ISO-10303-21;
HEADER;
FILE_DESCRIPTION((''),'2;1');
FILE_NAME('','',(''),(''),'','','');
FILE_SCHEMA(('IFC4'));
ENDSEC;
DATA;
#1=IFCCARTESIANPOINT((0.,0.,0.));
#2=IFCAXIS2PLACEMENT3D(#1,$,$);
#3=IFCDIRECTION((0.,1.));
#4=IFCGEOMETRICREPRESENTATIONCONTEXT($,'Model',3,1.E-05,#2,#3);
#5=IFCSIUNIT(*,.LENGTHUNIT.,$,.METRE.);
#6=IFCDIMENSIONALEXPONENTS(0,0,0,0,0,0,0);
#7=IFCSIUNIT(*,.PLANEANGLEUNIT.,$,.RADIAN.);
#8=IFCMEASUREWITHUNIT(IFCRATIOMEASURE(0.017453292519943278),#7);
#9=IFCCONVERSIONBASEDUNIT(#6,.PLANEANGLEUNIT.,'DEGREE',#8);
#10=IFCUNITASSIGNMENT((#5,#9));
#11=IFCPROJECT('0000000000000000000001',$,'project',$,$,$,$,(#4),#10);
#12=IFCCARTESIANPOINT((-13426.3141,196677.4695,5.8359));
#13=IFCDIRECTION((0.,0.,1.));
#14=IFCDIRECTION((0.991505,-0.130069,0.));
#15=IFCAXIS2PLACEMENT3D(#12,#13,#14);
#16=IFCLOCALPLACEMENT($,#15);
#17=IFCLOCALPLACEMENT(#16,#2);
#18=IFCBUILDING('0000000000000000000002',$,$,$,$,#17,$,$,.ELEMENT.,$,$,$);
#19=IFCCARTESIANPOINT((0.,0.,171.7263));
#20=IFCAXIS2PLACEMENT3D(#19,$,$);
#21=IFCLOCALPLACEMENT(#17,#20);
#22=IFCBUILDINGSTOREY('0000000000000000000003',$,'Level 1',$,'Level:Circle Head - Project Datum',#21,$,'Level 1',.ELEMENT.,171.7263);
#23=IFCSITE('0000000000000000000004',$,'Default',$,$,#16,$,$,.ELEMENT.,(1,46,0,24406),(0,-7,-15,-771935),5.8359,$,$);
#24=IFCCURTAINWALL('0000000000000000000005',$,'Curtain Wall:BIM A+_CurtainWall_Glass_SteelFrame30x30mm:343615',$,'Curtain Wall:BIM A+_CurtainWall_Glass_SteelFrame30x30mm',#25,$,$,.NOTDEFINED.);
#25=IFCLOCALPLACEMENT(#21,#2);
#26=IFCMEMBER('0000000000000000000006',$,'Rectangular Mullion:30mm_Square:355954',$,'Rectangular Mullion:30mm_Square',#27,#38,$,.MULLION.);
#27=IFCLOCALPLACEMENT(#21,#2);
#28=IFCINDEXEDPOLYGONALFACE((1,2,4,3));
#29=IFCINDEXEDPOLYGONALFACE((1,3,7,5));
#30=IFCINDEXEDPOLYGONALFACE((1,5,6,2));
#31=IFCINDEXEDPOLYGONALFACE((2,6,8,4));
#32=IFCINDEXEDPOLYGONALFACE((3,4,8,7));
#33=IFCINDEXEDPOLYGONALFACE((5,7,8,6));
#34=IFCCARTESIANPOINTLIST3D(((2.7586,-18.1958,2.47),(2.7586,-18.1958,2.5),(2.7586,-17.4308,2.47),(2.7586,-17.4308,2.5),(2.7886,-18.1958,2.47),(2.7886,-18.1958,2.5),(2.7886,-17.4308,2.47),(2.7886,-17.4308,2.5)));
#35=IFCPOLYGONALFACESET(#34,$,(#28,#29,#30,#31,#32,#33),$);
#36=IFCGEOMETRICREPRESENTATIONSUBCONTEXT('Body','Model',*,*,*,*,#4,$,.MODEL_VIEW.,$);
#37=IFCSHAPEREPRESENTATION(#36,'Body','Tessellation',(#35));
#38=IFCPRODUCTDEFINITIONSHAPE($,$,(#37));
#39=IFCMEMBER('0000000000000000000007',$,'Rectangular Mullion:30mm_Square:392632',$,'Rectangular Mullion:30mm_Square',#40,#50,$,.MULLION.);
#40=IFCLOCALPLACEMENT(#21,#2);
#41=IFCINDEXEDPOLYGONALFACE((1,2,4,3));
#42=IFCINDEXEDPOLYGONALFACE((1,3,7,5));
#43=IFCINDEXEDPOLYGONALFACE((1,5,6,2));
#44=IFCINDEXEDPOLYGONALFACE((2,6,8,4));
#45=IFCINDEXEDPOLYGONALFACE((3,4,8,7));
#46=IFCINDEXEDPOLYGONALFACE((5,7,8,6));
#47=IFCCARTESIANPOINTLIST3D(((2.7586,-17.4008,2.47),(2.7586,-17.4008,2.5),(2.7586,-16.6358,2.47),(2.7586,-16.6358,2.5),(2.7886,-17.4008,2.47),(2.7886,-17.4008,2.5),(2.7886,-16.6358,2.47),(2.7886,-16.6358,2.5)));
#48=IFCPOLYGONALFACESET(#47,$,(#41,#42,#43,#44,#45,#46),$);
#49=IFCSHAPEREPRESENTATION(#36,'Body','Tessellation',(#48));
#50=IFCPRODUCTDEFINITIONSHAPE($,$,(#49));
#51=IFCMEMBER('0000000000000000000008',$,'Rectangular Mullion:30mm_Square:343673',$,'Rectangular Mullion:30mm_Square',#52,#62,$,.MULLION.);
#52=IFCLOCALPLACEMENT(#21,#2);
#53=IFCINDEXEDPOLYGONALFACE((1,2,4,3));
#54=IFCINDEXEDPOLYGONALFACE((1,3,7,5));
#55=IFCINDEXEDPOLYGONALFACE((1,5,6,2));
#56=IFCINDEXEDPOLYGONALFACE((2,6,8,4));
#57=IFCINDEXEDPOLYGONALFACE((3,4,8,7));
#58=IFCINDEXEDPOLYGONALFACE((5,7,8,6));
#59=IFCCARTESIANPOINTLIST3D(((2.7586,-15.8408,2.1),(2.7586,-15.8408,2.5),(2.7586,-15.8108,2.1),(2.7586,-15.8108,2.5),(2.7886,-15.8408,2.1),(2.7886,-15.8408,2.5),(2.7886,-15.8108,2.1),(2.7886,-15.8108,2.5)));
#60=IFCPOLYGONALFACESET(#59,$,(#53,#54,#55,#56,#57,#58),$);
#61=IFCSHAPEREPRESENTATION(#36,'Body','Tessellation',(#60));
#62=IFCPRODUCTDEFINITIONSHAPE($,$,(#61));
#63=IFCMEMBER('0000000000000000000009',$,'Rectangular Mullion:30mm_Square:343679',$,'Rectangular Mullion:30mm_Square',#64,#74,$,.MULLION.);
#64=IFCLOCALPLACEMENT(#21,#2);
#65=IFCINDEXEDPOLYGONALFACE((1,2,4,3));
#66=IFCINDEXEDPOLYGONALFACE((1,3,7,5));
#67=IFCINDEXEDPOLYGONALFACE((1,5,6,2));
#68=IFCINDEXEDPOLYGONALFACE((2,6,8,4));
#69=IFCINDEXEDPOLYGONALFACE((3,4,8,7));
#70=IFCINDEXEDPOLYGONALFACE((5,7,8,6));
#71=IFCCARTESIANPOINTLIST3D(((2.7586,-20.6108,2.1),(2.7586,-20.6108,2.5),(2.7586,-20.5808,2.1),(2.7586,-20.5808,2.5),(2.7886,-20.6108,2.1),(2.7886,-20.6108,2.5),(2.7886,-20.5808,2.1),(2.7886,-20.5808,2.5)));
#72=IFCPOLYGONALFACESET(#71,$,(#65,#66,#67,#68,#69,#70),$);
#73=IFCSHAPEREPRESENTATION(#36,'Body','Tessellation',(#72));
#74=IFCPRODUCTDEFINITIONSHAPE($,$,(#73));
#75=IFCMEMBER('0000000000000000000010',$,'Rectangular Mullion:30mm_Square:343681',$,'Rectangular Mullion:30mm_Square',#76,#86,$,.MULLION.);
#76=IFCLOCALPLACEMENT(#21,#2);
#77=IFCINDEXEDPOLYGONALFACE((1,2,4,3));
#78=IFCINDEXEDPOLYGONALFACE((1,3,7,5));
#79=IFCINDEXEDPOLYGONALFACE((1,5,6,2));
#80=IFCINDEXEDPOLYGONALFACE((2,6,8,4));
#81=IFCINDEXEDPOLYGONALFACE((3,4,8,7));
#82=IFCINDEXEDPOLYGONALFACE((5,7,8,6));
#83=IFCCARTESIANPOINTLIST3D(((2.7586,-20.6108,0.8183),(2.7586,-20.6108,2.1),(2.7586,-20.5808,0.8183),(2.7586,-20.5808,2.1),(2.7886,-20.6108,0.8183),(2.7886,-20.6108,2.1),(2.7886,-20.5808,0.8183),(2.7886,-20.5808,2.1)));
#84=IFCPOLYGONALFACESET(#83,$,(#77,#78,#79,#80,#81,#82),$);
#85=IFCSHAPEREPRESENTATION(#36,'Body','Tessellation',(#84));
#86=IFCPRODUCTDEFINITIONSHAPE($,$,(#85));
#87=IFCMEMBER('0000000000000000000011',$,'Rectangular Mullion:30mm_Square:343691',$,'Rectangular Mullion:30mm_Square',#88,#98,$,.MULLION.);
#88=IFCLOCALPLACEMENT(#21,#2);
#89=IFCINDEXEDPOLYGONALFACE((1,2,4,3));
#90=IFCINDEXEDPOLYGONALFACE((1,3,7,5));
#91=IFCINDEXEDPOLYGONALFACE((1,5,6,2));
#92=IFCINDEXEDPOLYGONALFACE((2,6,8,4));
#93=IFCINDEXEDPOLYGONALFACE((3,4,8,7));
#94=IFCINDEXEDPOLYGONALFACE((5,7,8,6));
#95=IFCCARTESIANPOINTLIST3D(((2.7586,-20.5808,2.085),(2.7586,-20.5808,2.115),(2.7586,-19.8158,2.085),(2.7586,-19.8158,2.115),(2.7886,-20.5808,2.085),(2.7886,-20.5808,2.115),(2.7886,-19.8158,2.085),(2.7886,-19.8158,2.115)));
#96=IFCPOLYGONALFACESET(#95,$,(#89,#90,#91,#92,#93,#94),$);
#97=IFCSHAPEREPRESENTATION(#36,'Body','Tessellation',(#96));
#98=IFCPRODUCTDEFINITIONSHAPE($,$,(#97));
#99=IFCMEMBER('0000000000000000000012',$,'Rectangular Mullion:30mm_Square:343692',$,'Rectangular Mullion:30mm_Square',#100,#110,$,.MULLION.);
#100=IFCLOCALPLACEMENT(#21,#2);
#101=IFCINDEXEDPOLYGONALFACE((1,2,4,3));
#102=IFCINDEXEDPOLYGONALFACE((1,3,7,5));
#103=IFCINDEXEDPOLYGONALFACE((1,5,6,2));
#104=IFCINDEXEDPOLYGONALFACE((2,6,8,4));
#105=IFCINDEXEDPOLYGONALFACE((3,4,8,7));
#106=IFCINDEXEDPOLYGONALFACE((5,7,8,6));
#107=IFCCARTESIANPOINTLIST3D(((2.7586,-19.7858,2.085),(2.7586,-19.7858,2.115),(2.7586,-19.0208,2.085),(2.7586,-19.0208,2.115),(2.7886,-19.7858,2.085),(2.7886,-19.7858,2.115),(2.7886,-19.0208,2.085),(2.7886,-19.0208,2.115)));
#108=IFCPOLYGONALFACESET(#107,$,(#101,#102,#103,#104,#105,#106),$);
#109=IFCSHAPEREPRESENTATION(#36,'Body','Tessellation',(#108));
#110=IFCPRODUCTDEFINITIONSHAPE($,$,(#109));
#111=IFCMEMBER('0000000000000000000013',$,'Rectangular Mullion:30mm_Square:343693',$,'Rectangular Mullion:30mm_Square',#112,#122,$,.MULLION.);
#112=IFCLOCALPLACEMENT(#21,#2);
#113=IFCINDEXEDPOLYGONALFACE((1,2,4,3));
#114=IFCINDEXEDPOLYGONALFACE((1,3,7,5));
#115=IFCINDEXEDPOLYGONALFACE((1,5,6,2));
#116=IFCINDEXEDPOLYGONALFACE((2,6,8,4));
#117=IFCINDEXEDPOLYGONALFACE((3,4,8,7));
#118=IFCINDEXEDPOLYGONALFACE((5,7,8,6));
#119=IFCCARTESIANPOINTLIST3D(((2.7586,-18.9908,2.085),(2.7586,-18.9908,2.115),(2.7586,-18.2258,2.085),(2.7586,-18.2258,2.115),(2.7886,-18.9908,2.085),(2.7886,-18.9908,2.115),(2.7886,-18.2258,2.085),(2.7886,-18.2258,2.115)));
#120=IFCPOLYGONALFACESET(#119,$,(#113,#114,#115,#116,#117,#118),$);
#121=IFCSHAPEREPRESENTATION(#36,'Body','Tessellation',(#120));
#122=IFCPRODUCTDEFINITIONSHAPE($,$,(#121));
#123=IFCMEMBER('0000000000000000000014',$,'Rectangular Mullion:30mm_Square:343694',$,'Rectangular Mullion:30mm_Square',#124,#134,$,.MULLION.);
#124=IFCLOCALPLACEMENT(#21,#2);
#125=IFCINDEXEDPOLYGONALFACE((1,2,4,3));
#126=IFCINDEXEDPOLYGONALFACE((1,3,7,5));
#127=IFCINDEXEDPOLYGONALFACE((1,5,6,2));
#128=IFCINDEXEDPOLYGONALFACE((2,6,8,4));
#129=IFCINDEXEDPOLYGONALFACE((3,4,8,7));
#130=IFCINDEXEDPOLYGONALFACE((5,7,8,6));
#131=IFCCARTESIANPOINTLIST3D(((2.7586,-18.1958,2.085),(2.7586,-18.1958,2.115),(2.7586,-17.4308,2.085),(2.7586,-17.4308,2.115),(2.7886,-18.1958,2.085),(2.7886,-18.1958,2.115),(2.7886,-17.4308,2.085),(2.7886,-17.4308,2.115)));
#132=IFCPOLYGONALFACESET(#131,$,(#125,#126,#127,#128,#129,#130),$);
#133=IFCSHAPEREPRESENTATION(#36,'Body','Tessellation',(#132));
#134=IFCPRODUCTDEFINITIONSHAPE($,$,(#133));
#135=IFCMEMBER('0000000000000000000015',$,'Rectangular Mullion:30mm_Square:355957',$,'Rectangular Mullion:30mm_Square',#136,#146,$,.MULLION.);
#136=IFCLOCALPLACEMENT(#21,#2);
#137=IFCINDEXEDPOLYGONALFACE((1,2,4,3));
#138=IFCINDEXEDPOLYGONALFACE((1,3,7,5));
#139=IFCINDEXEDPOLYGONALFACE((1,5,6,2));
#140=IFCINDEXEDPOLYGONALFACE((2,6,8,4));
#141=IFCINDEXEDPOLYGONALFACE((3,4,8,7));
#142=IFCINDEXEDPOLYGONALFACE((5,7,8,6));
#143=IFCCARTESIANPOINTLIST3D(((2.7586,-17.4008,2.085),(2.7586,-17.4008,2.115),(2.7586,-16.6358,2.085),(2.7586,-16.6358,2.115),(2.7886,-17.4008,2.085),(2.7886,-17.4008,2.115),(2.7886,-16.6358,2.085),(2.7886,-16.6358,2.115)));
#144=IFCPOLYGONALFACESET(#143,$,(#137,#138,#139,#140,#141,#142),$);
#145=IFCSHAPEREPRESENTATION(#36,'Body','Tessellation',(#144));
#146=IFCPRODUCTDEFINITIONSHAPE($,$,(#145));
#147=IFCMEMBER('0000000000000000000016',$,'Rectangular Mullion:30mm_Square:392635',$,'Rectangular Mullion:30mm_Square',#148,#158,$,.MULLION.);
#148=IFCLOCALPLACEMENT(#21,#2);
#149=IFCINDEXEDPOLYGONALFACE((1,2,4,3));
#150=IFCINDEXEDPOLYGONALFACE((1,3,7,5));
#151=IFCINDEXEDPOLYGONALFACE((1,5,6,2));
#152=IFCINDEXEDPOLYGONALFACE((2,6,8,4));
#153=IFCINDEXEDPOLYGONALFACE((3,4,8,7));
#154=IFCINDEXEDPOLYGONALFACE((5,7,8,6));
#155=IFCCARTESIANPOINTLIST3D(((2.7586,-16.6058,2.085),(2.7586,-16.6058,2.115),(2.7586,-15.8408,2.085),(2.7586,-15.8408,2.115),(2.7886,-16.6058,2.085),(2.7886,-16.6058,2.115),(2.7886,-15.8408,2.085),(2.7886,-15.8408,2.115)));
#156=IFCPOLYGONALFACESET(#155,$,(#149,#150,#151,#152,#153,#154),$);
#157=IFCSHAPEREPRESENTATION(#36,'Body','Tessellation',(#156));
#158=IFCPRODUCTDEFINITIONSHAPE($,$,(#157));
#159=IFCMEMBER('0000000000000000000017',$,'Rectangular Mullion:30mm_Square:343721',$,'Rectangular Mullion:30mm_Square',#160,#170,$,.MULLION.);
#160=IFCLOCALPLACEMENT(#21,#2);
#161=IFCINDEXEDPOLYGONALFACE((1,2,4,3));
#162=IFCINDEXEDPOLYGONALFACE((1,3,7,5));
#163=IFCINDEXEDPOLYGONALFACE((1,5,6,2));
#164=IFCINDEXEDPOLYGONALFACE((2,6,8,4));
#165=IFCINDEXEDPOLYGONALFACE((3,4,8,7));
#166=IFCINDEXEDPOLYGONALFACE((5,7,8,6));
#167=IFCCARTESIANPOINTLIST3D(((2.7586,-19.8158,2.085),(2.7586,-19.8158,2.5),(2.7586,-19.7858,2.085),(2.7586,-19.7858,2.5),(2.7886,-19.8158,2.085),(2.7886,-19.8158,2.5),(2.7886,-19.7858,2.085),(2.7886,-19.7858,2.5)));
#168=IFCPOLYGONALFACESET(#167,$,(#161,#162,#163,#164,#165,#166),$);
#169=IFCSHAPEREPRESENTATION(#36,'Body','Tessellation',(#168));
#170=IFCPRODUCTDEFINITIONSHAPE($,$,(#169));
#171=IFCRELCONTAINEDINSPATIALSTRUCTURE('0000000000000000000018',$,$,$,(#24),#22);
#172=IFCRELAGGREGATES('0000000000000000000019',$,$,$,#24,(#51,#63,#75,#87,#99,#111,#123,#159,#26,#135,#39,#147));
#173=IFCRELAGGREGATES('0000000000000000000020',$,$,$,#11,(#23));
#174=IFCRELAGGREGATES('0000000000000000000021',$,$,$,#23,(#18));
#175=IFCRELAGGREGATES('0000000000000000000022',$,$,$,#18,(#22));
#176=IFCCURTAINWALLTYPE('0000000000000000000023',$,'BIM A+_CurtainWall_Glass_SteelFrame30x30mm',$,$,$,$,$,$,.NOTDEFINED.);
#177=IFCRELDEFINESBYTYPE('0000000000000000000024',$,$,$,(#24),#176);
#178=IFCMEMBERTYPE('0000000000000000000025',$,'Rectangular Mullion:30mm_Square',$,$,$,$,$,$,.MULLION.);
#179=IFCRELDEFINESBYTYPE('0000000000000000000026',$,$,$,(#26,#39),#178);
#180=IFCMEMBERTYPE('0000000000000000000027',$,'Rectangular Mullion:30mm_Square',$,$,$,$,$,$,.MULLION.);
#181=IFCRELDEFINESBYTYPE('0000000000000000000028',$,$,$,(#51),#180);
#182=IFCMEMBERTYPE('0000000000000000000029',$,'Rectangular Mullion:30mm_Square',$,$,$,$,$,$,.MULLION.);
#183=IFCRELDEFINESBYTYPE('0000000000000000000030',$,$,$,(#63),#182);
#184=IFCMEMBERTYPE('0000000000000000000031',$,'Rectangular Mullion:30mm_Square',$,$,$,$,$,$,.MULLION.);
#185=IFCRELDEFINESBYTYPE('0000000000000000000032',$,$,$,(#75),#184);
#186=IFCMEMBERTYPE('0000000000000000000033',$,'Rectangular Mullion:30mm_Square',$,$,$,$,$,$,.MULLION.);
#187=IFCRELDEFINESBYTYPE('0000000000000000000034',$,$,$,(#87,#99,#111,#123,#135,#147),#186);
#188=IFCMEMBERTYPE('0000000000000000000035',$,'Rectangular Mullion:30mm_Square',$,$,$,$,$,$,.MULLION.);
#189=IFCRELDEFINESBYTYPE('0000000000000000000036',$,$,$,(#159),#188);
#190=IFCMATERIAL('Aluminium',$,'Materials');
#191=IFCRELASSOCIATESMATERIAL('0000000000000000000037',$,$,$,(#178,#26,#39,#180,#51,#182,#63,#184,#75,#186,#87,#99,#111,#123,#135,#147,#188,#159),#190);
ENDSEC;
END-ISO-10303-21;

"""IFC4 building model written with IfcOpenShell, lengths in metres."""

from ifc_helpers import new_model, entity, si_unit, converted_unit, direction, frame, origin, place, context, subcontext, project, spatial, indexed_curve, outline, extrude, source, transform, mapped, material, type_object, type_shapes, element, aggregate, save


model = new_model("IFC4")

# Units and contexts
model_context = context("Model", 3, precision=1e-05, world=origin(), true_north=direction((0.0, 1.0)))
body_context = subcontext(model_context, "Body", "Model", "MODEL_VIEW")
ifc_project = project(units=[si_unit("LENGTHUNIT", "METRE"), converted_unit("PLANEANGLEUNIT", "DEGREE", entity("IfcRatioMeasure", 0.017453292519943278), si_unit("PLANEANGLEUNIT", "RADIAN"), dimensions=[0, 0, 0, 0, 0, 0, 0])], contexts=[model_context])

# Site, building, storey
site_placement = place(None, frame((-13426.3141, 196677.4695, 5.8359), z_axis=(0.0, 0.0, 1.0), x_axis=(0.991505, -0.130069, 0.0)))
site = spatial("IfcSite", under=ifc_project, at=site_placement, Name="Default", CompositionType="ELEMENT", RefLatitude=(1, 46, 0, 24406), RefLongitude=(0, -7, -15, -771935), RefElevation=5.8359)
building_placement = place(site_placement, origin())
building = spatial("IfcBuilding", under=site, at=building_placement, CompositionType="ELEMENT")
storey_placement = place(building_placement, frame((0.0, 0.0, 171.7263)))
storey = spatial("IfcBuildingStorey", under=building, at=storey_placement, Name="Level 1", ObjectType="Level:Circle Head - Project Datum", LongName="Level 1", CompositionType="ELEMENT", Elevation=171.7263)

# Curtain wall, members
curtain_wall_type_1 = type_object("IfcCurtainWallType", Name="BIM A+_CurtainWall_Glass_SteelFrame30x30mm", PredefinedType="NOTDEFINED")
ifc_material_1 = material(Name="Aluminium", Category="Materials")
curtain_wall_1_placement = place(storey_placement, frame((0.0, 0.0, -171.7263)))
curtain_wall_1 = element("IfcCurtainWall", 1, at=curtain_wall_1_placement, inside=storey, type_object=curtain_wall_type_1, Name="Curtain Wall:BIM A+_CurtainWall_Glass_SteelFrame30x30mm:343615", ObjectType="Curtain Wall:BIM A+_CurtainWall_Glass_SteelFrame30x30mm", PredefinedType="NOTDEFINED")
member_type_1 = type_object("IfcMemberType", Name="Rectangular Mullion:30mm_Square", PredefinedType="MULLION", material=ifc_material_1)
shared_shape_1 = source(origin(), body_context, "Body", "SweptSolid", [
    extrude(outline(indexed_curve([(-0.015, -0.015), (0.015, -0.015), (0.015, 0.015), (-0.015, 0.015), (-0.015, -0.015)], self_intersect=False)), frame((-0.015, 0.0, -0.765), z_axis=(0.0, 0.0, 1.0), x_axis=(0.0, -1.0, 0.0)), (0.0, 0.0, 1.0), 0.765),
])
type_shapes(member_type_1, [shared_shape_1])
member_1_placement = place(curtain_wall_1_placement, frame((2.7736, -17.4308, 174.2263), z_axis=(0.0, 1.0, 0.0), x_axis=(0.0, 0.0, 1.0)))
member_1 = element("IfcMember", 2, at=member_1_placement, type_object=member_type_1, material=ifc_material_1, Name="Rectangular Mullion:30mm_Square:355954", ObjectType="Rectangular Mullion:30mm_Square", PredefinedType="MULLION", context=body_context, shape_type="MappedRepresentation", body=[
    mapped(shared_shape_1, transform((0.0, 0.0, 0.0), scale=1.0)),
])
member_2_placement = place(curtain_wall_1_placement, frame((2.7736, -16.6358, 174.2263), z_axis=(0.0, 1.0, 0.0), x_axis=(0.0, 0.0, 1.0)))
member_2 = element("IfcMember", 3, at=member_2_placement, type_object=member_type_1, material=ifc_material_1, Name="Rectangular Mullion:30mm_Square:392632", ObjectType="Rectangular Mullion:30mm_Square", PredefinedType="MULLION", context=body_context, shape_type="MappedRepresentation", body=[
    mapped(shared_shape_1, transform((0.0, 0.0, 0.0), scale=1.0)),
])
member_type_2 = type_object("IfcMemberType", Name="Rectangular Mullion:30mm_Square", PredefinedType="MULLION", material=ifc_material_1)
shared_shape_2 = source(origin(), body_context, "Body", "SweptSolid", [
    extrude(outline(indexed_curve([(-0.015, -0.015), (0.015, -0.015), (0.015, 0.015), (-0.015, 0.015), (-0.015, -0.015)], self_intersect=False)), frame((-0.015, 0.0, -0.4), z_axis=(0.0, 0.0, 1.0), x_axis=(0.0, -1.0, 0.0)), (0.0, 0.0, 1.0), 0.4),
])
type_shapes(member_type_2, [shared_shape_2])
member_3_placement = place(curtain_wall_1_placement, frame((2.7736, -15.8108, 173.8263), z_axis=(0.0, 0.0, -1.0), x_axis=(0.0, 1.0, 0.0)))
member_3 = element("IfcMember", 4, at=member_3_placement, type_object=member_type_2, material=ifc_material_1, Name="Rectangular Mullion:30mm_Square:343673", ObjectType="Rectangular Mullion:30mm_Square", PredefinedType="MULLION", context=body_context, shape_type="MappedRepresentation", body=[
    mapped(shared_shape_2, transform((0.0, 0.0, 0.0), scale=1.0)),
])
member_type_3 = type_object("IfcMemberType", Name="Rectangular Mullion:30mm_Square", PredefinedType="MULLION", material=ifc_material_1)
shared_shape_3 = source(origin(), body_context, "Body", "SweptSolid", [
    extrude(outline(indexed_curve([(-0.015, -0.015), (0.015, -0.015), (0.015, 0.015), (-0.015, 0.015), (-0.015, -0.015)], self_intersect=False)), frame((-0.015, 0.0, -0.4), z_axis=(0.0, 0.0, 1.0), x_axis=(0.0, -1.0, 0.0)), (0.0, 0.0, 1.0), 0.4),
])
type_shapes(member_type_3, [shared_shape_3])
member_4_placement = place(curtain_wall_1_placement, frame((2.7736, -20.6108, 174.2263), z_axis=(0.0, 0.0, 1.0), x_axis=(0.0, -1.0, 0.0)))
member_4 = element("IfcMember", 5, at=member_4_placement, type_object=member_type_3, material=ifc_material_1, Name="Rectangular Mullion:30mm_Square:343679", ObjectType="Rectangular Mullion:30mm_Square", PredefinedType="MULLION", context=body_context, shape_type="MappedRepresentation", body=[
    mapped(shared_shape_3, transform((0.0, 0.0, 0.0), scale=1.0)),
])
member_type_4 = type_object("IfcMemberType", Name="Rectangular Mullion:30mm_Square", PredefinedType="MULLION", material=ifc_material_1)
shared_shape_4 = source(origin(), body_context, "Body", "SweptSolid", [
    extrude(outline(indexed_curve([(-0.015, -0.015), (0.015, -0.015), (0.015, 0.015), (-0.015, 0.015), (-0.015, -0.015)], self_intersect=False)), frame((-0.015, 0.0, -1.2817), z_axis=(0.0, 0.0, 1.0), x_axis=(0.0, -1.0, 0.0)), (0.0, 0.0, 1.0), 1.2817),
])
type_shapes(member_type_4, [shared_shape_4])
member_5_placement = place(curtain_wall_1_placement, frame((2.7736, -20.6108, 173.8263), z_axis=(0.0, 0.0, 1.0), x_axis=(0.0, -1.0, 0.0)))
member_5 = element("IfcMember", 6, at=member_5_placement, type_object=member_type_4, material=ifc_material_1, Name="Rectangular Mullion:30mm_Square:343681", ObjectType="Rectangular Mullion:30mm_Square", PredefinedType="MULLION", context=body_context, shape_type="MappedRepresentation", body=[
    mapped(shared_shape_4, transform((0.0, 0.0, 0.0), scale=1.0)),
])
member_type_5 = type_object("IfcMemberType", Name="Rectangular Mullion:30mm_Square", PredefinedType="MULLION", material=ifc_material_1)
shared_shape_5 = source(origin(), body_context, "Body", "SweptSolid", [
    extrude(outline(indexed_curve([(-0.015, -0.015), (0.015, -0.015), (0.015, 0.015), (-0.015, 0.015), (-0.015, -0.015)], self_intersect=False)), frame((0.0, 0.0, -0.765), z_axis=(0.0, 0.0, 1.0), x_axis=(0.0, -1.0, 0.0)), (0.0, 0.0, 1.0), 0.765),
])
type_shapes(member_type_5, [shared_shape_5])
member_6_placement = place(curtain_wall_1_placement, frame((2.7736, -19.8158, 173.8263), z_axis=(0.0, 1.0, 0.0), x_axis=(0.0, 0.0, 1.0)))
member_6 = element("IfcMember", 7, at=member_6_placement, type_object=member_type_5, material=ifc_material_1, Name="Rectangular Mullion:30mm_Square:343691", ObjectType="Rectangular Mullion:30mm_Square", PredefinedType="MULLION", context=body_context, shape_type="MappedRepresentation", body=[
    mapped(shared_shape_5, transform((0.0, 0.0, 0.0), scale=1.0)),
])
member_7_placement = place(curtain_wall_1_placement, frame((2.7736, -19.0208, 173.8263), z_axis=(0.0, 1.0, 0.0), x_axis=(0.0, 0.0, 1.0)))
member_7 = element("IfcMember", 8, at=member_7_placement, type_object=member_type_5, material=ifc_material_1, Name="Rectangular Mullion:30mm_Square:343692", ObjectType="Rectangular Mullion:30mm_Square", PredefinedType="MULLION", context=body_context, shape_type="MappedRepresentation", body=[
    mapped(shared_shape_5, transform((0.0, 0.0, 0.0), scale=1.0)),
])
member_8_placement = place(curtain_wall_1_placement, frame((2.7736, -18.2258, 173.8263), z_axis=(0.0, 1.0, 0.0), x_axis=(0.0, 0.0, 1.0)))
member_8 = element("IfcMember", 9, at=member_8_placement, type_object=member_type_5, material=ifc_material_1, Name="Rectangular Mullion:30mm_Square:343693", ObjectType="Rectangular Mullion:30mm_Square", PredefinedType="MULLION", context=body_context, shape_type="MappedRepresentation", body=[
    mapped(shared_shape_5, transform((0.0, 0.0, 0.0), scale=1.0)),
])
member_9_placement = place(curtain_wall_1_placement, frame((2.7736, -17.4308, 173.8263), z_axis=(0.0, 1.0, 0.0), x_axis=(0.0, 0.0, 1.0)))
member_9 = element("IfcMember", 10, at=member_9_placement, type_object=member_type_5, material=ifc_material_1, Name="Rectangular Mullion:30mm_Square:343694", ObjectType="Rectangular Mullion:30mm_Square", PredefinedType="MULLION", context=body_context, shape_type="MappedRepresentation", body=[
    mapped(shared_shape_5, transform((0.0, 0.0, 0.0), scale=1.0)),
])
member_10_placement = place(curtain_wall_1_placement, frame((2.7736, -16.6358, 173.8263), z_axis=(0.0, 1.0, 0.0), x_axis=(0.0, 0.0, 1.0)))
member_10 = element("IfcMember", 11, at=member_10_placement, type_object=member_type_5, material=ifc_material_1, Name="Rectangular Mullion:30mm_Square:355957", ObjectType="Rectangular Mullion:30mm_Square", PredefinedType="MULLION", context=body_context, shape_type="MappedRepresentation", body=[
    mapped(shared_shape_5, transform((0.0, 0.0, 0.0), scale=1.0)),
])
member_11_placement = place(curtain_wall_1_placement, frame((2.7736, -15.8408, 173.8263), z_axis=(0.0, 1.0, 0.0), x_axis=(0.0, 0.0, 1.0)))
member_11 = element("IfcMember", 12, at=member_11_placement, type_object=member_type_5, material=ifc_material_1, Name="Rectangular Mullion:30mm_Square:392635", ObjectType="Rectangular Mullion:30mm_Square", PredefinedType="MULLION", context=body_context, shape_type="MappedRepresentation", body=[
    mapped(shared_shape_5, transform((0.0, 0.0, 0.0), scale=1.0)),
])
member_type_6 = type_object("IfcMemberType", Name="Rectangular Mullion:30mm_Square", PredefinedType="MULLION", material=ifc_material_1)
shared_shape_6 = source(origin(), body_context, "Body", "SweptSolid", [
    extrude(outline(indexed_curve([(-0.015, -0.015), (0.015, -0.015), (0.015, 0.015), (-0.015, 0.015), (-0.015, -0.015)], self_intersect=False)), frame((0.0, 0.0, -0.415), z_axis=(0.0, 0.0, 1.0), x_axis=(0.0, -1.0, 0.0)), (0.0, 0.0, 1.0), 0.415),
])
type_shapes(member_type_6, [shared_shape_6])
member_12_placement = place(curtain_wall_1_placement, frame((2.7736, -19.8008, 173.8113), z_axis=(0.0, 0.0, -1.0), x_axis=(0.0, 1.0, 0.0)))
member_12 = element("IfcMember", 13, at=member_12_placement, type_object=member_type_6, material=ifc_material_1, Name="Rectangular Mullion:30mm_Square:343721", ObjectType="Rectangular Mullion:30mm_Square", PredefinedType="MULLION", context=body_context, shape_type="MappedRepresentation", body=[
    mapped(shared_shape_6, transform((0.0, 0.0, 0.0), scale=1.0)),
])

aggregate(curtain_wall_1, [member_3, member_4, member_5, member_6, member_7, member_8, member_9, member_12, member_1, member_10, member_2, member_11])

save(model, "model.ifc")
